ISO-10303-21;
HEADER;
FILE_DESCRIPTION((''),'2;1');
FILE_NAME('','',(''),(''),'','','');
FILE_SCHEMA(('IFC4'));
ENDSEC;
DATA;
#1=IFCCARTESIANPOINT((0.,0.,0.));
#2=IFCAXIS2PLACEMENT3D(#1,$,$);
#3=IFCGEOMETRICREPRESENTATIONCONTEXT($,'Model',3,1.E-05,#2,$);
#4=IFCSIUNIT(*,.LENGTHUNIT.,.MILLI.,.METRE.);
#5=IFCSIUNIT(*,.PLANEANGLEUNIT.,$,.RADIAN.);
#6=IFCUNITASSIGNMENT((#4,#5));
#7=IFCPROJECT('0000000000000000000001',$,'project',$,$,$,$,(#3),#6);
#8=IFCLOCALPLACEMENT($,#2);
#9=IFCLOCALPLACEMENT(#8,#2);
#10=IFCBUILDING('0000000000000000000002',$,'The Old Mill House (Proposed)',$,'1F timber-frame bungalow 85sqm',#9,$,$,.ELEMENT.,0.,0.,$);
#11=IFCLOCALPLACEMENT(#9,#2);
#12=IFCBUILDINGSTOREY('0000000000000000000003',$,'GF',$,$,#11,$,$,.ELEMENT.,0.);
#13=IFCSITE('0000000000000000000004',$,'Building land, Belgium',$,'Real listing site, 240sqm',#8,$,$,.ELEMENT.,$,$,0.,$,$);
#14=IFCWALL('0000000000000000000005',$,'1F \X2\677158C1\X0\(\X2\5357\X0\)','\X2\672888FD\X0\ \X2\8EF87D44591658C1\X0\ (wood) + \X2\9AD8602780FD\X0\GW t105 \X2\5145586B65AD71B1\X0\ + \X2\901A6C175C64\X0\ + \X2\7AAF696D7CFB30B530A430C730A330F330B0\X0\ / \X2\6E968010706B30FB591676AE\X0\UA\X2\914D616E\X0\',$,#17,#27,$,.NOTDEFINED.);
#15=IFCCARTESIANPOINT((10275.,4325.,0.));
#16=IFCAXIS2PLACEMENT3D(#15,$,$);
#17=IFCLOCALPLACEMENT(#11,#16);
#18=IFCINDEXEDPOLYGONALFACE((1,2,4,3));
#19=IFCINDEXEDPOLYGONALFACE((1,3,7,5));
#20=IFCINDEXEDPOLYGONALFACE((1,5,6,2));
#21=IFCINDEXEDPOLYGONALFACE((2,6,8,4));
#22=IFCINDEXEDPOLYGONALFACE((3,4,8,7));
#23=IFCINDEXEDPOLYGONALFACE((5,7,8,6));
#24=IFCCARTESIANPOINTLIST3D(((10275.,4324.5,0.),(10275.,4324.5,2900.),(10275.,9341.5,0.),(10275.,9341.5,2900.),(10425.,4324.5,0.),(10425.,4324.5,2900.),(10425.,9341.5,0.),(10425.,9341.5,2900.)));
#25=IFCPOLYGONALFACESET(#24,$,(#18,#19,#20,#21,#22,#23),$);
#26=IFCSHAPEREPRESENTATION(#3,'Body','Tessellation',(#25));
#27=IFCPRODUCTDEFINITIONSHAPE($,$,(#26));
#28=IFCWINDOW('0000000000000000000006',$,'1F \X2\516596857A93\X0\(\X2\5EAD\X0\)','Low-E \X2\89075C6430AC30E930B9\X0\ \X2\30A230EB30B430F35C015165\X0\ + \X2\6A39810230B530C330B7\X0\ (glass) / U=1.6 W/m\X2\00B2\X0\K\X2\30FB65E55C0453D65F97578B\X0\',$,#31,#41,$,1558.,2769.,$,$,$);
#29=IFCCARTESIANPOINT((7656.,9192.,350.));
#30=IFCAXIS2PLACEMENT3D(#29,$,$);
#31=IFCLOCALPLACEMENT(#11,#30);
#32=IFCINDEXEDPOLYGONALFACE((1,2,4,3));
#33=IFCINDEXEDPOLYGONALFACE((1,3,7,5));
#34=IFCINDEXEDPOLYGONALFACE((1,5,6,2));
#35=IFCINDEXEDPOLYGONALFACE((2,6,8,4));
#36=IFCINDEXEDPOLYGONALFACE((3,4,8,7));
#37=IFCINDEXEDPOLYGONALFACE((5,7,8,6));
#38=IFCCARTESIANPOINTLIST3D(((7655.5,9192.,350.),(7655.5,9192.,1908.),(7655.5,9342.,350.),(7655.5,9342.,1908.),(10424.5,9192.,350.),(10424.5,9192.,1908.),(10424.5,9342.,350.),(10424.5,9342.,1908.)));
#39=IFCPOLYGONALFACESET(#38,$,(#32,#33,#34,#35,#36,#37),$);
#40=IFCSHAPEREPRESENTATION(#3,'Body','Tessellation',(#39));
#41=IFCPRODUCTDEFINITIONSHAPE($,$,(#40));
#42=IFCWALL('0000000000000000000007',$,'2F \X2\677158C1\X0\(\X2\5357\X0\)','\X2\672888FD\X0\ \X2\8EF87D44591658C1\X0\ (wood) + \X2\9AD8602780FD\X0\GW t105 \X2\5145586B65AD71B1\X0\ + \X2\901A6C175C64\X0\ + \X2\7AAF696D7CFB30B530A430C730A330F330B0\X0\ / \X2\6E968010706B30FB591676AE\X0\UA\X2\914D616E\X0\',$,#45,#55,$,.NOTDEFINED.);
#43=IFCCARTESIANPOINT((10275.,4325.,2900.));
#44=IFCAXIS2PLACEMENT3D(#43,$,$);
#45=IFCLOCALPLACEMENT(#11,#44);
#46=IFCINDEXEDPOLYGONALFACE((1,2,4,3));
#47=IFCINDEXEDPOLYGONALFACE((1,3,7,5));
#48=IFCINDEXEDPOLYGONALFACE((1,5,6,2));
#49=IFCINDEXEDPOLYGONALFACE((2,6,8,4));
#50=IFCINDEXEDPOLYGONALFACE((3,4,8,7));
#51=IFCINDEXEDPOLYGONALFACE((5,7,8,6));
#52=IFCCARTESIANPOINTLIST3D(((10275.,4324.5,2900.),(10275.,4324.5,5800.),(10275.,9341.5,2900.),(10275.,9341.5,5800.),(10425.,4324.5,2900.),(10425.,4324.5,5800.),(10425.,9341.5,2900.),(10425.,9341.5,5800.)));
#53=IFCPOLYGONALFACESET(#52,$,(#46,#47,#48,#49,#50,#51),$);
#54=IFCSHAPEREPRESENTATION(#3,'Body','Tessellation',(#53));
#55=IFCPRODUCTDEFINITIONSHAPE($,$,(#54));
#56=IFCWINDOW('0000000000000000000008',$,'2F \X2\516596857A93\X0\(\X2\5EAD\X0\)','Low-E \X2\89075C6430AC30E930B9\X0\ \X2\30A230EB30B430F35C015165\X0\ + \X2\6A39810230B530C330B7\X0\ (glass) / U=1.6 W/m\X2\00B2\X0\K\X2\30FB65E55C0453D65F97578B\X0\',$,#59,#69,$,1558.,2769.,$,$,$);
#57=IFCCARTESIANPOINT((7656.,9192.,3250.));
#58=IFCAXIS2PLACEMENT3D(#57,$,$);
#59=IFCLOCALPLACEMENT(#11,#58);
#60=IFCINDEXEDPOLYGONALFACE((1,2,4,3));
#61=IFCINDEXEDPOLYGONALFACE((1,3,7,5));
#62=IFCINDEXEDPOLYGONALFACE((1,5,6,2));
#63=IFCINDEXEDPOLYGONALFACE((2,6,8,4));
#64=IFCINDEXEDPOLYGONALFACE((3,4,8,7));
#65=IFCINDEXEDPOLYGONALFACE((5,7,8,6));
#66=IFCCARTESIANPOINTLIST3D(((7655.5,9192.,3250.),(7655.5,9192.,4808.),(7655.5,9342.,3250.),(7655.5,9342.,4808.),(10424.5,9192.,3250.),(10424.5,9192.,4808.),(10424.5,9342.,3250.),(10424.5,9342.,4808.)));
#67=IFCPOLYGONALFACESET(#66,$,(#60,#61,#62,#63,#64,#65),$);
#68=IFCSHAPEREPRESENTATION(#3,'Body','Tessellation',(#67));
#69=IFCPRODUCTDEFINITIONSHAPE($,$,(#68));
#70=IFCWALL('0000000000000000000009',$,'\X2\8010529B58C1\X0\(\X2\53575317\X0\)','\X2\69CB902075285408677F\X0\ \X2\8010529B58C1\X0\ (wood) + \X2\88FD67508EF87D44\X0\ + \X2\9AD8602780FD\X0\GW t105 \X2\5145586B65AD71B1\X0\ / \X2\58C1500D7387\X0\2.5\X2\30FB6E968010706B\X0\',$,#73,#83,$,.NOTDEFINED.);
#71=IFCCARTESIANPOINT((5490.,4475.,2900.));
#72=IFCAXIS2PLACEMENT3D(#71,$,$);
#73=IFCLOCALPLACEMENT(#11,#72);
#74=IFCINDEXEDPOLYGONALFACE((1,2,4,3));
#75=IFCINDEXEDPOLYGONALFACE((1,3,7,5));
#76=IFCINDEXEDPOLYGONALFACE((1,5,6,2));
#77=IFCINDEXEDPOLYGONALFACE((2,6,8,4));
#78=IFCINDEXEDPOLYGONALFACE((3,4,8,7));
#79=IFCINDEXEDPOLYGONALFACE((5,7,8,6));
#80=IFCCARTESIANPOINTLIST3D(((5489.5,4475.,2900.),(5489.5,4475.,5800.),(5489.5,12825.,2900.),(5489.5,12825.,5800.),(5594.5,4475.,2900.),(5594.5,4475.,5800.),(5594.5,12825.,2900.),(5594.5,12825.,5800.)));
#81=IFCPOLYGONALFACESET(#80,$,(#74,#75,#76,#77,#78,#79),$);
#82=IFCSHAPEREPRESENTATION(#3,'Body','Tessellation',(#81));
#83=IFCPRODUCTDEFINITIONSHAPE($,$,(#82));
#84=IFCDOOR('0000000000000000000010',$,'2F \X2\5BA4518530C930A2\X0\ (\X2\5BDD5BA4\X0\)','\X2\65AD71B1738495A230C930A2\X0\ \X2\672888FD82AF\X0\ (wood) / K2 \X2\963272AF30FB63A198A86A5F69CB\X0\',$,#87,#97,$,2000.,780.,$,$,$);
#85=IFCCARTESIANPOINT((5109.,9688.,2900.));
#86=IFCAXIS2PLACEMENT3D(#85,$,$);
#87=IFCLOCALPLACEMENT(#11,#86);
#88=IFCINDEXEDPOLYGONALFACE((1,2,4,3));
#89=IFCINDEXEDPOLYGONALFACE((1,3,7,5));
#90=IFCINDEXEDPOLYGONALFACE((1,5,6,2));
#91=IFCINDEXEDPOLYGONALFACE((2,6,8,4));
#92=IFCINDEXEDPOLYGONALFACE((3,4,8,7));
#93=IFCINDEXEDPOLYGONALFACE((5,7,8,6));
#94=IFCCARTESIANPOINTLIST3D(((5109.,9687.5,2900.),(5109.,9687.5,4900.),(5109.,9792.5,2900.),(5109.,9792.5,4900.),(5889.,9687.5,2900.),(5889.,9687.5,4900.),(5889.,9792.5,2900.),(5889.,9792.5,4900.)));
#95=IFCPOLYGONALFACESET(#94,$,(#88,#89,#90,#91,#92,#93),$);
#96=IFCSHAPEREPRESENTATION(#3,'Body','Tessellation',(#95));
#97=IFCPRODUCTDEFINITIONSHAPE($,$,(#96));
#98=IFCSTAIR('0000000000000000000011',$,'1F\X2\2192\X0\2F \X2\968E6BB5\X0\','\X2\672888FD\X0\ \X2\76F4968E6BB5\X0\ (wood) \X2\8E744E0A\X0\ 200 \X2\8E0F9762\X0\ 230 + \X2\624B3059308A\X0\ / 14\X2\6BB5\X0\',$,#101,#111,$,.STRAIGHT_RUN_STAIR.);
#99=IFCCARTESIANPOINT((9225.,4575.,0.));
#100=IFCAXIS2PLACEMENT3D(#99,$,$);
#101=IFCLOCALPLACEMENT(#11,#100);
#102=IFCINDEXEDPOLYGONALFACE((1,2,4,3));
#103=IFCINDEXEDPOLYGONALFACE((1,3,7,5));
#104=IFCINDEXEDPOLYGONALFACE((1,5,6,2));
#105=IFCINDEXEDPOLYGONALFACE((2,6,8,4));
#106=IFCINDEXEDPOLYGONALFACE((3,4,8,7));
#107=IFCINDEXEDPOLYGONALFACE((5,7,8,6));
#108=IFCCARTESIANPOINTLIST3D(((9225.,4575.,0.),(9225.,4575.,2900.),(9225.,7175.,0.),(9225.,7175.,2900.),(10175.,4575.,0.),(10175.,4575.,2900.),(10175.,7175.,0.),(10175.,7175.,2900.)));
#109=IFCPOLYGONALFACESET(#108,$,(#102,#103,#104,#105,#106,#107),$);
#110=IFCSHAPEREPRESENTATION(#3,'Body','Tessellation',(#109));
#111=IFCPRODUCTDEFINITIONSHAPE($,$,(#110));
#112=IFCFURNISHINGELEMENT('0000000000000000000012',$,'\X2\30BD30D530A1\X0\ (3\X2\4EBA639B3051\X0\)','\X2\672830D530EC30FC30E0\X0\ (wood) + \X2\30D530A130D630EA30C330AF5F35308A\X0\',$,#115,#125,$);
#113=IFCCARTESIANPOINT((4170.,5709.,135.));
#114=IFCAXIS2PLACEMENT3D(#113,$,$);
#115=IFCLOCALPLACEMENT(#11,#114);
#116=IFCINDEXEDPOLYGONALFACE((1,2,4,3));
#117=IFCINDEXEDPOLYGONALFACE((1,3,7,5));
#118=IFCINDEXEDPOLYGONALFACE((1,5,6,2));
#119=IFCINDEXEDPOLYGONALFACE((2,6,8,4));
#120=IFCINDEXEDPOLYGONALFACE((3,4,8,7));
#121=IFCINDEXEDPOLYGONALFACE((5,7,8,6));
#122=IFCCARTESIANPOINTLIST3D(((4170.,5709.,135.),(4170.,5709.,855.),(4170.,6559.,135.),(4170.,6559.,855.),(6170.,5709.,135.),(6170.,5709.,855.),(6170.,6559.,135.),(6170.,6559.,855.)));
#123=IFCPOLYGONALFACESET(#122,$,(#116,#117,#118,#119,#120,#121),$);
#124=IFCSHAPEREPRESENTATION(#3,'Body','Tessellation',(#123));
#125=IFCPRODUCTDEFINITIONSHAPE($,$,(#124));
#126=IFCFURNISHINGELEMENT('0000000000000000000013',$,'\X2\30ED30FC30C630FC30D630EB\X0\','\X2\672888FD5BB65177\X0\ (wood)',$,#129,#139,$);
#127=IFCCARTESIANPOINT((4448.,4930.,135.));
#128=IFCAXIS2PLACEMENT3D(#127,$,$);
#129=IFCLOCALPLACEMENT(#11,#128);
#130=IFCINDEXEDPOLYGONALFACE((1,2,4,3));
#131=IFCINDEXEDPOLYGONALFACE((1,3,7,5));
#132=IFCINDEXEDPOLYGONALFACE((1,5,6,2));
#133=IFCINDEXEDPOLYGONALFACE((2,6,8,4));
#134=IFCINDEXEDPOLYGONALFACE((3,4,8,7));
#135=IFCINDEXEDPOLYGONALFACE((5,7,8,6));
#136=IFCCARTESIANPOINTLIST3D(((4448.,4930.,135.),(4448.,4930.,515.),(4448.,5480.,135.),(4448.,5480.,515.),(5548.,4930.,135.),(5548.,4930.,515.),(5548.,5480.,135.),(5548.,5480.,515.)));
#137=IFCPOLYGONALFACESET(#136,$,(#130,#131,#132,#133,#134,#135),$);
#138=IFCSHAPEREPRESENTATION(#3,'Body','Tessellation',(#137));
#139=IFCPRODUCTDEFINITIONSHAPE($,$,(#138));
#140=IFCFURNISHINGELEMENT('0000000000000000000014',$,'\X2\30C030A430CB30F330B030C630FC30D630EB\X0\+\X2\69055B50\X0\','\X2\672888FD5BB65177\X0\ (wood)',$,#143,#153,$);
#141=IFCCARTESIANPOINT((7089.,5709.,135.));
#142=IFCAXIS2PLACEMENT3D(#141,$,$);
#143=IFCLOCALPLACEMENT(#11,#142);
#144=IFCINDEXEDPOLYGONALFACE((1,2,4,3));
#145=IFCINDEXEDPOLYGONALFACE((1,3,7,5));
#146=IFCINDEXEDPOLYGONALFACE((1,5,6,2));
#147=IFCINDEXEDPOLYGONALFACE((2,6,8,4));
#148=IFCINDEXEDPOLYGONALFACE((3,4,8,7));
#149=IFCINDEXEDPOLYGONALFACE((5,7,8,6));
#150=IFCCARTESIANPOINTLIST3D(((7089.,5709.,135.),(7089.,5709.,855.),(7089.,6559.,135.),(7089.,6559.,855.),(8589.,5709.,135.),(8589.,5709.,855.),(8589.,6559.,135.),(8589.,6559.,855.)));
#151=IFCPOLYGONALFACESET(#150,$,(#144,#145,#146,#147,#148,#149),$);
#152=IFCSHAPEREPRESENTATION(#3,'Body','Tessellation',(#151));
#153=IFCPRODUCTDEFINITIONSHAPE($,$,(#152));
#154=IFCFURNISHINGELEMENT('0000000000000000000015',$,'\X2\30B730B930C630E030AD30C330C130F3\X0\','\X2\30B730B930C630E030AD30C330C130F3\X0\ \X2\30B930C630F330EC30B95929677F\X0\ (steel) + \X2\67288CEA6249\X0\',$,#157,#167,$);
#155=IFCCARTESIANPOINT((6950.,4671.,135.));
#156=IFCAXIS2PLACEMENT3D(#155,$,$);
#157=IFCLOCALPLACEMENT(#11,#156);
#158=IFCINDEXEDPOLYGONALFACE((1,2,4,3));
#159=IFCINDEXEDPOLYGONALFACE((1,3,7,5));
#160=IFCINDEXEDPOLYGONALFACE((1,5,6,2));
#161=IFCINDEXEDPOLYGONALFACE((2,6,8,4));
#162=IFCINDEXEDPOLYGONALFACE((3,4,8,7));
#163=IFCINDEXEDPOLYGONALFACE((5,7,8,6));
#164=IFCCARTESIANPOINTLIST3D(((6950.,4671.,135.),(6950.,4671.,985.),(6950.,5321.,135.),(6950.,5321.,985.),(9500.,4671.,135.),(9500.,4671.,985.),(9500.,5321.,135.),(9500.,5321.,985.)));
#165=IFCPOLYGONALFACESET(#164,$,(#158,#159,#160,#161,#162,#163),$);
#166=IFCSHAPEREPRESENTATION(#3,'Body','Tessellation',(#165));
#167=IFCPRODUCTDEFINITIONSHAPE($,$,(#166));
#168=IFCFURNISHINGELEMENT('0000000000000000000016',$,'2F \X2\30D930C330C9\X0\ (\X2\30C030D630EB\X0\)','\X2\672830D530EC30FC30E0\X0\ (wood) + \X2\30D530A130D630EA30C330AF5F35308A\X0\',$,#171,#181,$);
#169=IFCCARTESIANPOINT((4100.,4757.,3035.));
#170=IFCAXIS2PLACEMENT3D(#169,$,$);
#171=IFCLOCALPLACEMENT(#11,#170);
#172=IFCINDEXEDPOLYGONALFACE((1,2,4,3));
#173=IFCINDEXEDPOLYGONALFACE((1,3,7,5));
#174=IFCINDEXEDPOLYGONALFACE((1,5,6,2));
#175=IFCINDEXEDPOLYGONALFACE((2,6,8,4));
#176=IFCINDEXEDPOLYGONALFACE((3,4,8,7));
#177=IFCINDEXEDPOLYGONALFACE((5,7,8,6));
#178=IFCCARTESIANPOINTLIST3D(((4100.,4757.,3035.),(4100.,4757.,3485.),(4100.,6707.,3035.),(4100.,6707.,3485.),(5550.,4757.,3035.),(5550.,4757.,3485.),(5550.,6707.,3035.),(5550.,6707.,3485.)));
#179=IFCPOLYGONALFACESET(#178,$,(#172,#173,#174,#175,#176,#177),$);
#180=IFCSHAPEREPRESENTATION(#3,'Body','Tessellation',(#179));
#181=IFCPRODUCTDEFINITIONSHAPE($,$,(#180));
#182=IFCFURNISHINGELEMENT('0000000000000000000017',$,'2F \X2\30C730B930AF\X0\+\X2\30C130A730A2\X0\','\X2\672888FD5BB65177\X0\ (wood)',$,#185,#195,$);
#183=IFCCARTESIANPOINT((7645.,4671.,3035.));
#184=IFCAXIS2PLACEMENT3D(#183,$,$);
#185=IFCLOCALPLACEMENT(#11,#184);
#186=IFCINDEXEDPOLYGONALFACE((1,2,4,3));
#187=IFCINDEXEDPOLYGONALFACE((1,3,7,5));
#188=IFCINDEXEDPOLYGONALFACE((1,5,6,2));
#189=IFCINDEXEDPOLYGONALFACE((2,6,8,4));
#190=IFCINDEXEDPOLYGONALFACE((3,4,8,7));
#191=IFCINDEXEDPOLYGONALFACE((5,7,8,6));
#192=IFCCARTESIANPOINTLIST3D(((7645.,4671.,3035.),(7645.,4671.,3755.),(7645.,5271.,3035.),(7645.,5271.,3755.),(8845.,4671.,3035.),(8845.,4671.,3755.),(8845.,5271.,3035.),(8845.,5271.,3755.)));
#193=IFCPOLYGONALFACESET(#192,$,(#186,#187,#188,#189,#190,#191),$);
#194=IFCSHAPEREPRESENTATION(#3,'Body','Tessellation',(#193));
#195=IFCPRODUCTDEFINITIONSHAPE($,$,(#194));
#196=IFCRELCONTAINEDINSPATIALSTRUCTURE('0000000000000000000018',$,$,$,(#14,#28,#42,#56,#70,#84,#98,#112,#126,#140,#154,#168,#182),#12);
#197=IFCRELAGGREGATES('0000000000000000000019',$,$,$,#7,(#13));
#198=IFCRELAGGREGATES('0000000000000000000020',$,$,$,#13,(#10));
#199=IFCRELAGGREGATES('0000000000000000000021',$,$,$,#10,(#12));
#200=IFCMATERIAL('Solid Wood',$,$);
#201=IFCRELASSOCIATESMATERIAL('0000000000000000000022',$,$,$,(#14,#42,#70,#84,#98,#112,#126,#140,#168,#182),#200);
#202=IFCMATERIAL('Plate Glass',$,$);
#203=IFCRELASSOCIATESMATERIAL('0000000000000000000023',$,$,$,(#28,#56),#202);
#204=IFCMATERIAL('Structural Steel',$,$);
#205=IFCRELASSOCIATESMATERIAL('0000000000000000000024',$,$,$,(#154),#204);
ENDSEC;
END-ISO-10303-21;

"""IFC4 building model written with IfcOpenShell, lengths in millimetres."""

from ifc_helpers import new_model, si_unit, frame, frame_2d, origin, place, context, project, spatial, rectangle, extrude, material, element, fill, save


model = new_model("IFC4")

# Units and contexts
model_context = context("Model", 3, precision=1e-05, world=origin())
ifc_project = project(units=[si_unit("LENGTHUNIT", "METRE", prefix="MILLI"), si_unit("PLANEANGLEUNIT", "RADIAN")], contexts=[model_context])

# Site, building, storey
site_placement = place(None, origin())
site = spatial("IfcSite", under=ifc_project, at=site_placement, Name="Building land, Belgium", ObjectType="Real listing site, 240sqm", CompositionType="ELEMENT", RefElevation=0.0)
building_placement = place(site_placement, origin())
building = spatial("IfcBuilding", under=site, at=building_placement, Name="The Old Mill House (Proposed)", ObjectType="1F timber-frame bungalow 85sqm", CompositionType="ELEMENT", ElevationOfRefHeight=0.0, ElevationOfTerrain=0.0)
storey_placement = place(building_placement, origin())
storey = spatial("IfcBuildingStorey", under=building, at=storey_placement, Name="GF", CompositionType="ELEMENT", Elevation=0.0)

# Wall, opening, window
ifc_material_1 = material(Name="Solid Wood")
wall_1_placement = place(storey_placement, frame((10275.0, 4325.0, 0.0)))
wall_1 = element("IfcWall", 1, at=wall_1_placement, inside=storey, material=ifc_material_1, Name="1F 東壁(南)", Description="木製 軸組外壁 (wood) + 高性能GW t105 充填断熱 + 通気層 + 窯業系サイディング / 準耐火・外皮UA配慮", PredefinedType="NOTDEFINED", context=model_context, shape_type="SweptSolid", body=[
    extrude(rectangle(XDim=150.0, YDim=5017.0, at=frame_2d((75.0, 2508.0))), frame((10275.0, 4325.0, 0.0)), (0.0, 0.0, 1.0), 2900.0),
])
opening_1_placement = place(storey_placement, frame((7656.0, 9192.0, 350.0)))
opening_1 = element("IfcOpeningElement", 2, at=opening_1_placement, cuts=wall_1, PredefinedType="NOTDEFINED", context=model_context, shape_type="SweptSolid", body=[
    extrude(rectangle(XDim=2769.0, YDim=150.0, at=frame_2d((1384.0, 75.0))), frame((7656.0, 9192.0, 350.0)), (0.0, 0.0, 1.0), 1558.0),
])
ifc_material_2 = material(Name="Plate Glass")
window_1_placement = place(storey_placement, frame((7656.0, 9192.0, 350.0)))
window_1 = element("IfcWindow", 3, at=window_1_placement, inside=storey, material=ifc_material_2, Name="1F 入隅窓(庭)", Description="Low-E 複層ガラス アルゴン封入 + 樹脂サッシ (glass) / U=1.6 W/m²K・日射取得型", OverallHeight=1558.0, OverallWidth=2769.0, context=model_context, shape_type="SweptSolid", body=[
    extrude(rectangle(XDim=2769.0, YDim=150.0, at=frame_2d((1384.0, 75.0))), frame((7656.0, 9192.0, 350.0)), (0.0, 0.0, 1.0), 1558.0),
])
fill(opening_1, window_1)

# Wall, opening, window
wall_2_placement = place(storey_placement, frame((10275.0, 4325.0, 2900.0)))
wall_2 = element("IfcWall", 4, at=wall_2_placement, inside=storey, material=ifc_material_1, Name="2F 東壁(南)", Description="木製 軸組外壁 (wood) + 高性能GW t105 充填断熱 + 通気層 + 窯業系サイディング / 準耐火・外皮UA配慮", PredefinedType="NOTDEFINED", context=model_context, shape_type="SweptSolid", body=[
    extrude(rectangle(XDim=150.0, YDim=5017.0, at=frame_2d((75.0, 2508.0))), frame((10275.0, 4325.0, 2900.0)), (0.0, 0.0, 1.0), 2900.0),
])
opening_2_placement = place(storey_placement, frame((7656.0, 9192.0, 3250.0)))
opening_2 = element("IfcOpeningElement", 5, at=opening_2_placement, cuts=wall_2, PredefinedType="NOTDEFINED", context=model_context, shape_type="SweptSolid", body=[
    extrude(rectangle(XDim=2769.0, YDim=150.0, at=frame_2d((1384.0, 75.0))), frame((7656.0, 9192.0, 3250.0)), (0.0, 0.0, 1.0), 1558.0),
])
window_2_placement = place(storey_placement, frame((7656.0, 9192.0, 3250.0)))
window_2 = element("IfcWindow", 6, at=window_2_placement, inside=storey, material=ifc_material_2, Name="2F 入隅窓(庭)", Description="Low-E 複層ガラス アルゴン封入 + 樹脂サッシ (glass) / U=1.6 W/m²K・日射取得型", OverallHeight=1558.0, OverallWidth=2769.0, context=model_context, shape_type="SweptSolid", body=[
    extrude(rectangle(XDim=2769.0, YDim=150.0, at=frame_2d((1384.0, 75.0))), frame((7656.0, 9192.0, 3250.0)), (0.0, 0.0, 1.0), 1558.0),
])
fill(opening_2, window_2)

# Wall, opening, door
wall_3_placement = place(storey_placement, frame((5490.0, 4475.0, 2900.0)))
wall_3 = element("IfcWall", 7, at=wall_3_placement, inside=storey, material=ifc_material_1, Name="耐力壁(南北)", Description="構造用合板 耐力壁 (wood) + 製材軸組 + 高性能GW t105 充填断熱 / 壁倍率2.5・準耐火", PredefinedType="NOTDEFINED", context=model_context, shape_type="SweptSolid", body=[
    extrude(rectangle(XDim=105.0, YDim=8350.0, at=frame_2d((52.0, 4175.0))), frame((5490.0, 4475.0, 2900.0)), (0.0, 0.0, 1.0), 2900.0),
])
opening_3_placement = place(storey_placement, frame((5109.0, 9688.0, 2900.0)))
opening_3 = element("IfcOpeningElement", 8, at=opening_3_placement, cuts=wall_3, PredefinedType="NOTDEFINED", context=model_context, shape_type="SweptSolid", body=[
    extrude(rectangle(XDim=780.0, YDim=105.0, at=frame_2d((390.0, 52.0))), frame((5109.0, 9688.0, 2900.0)), (0.0, 0.0, 1.0), 2000.0),
])
door_1_placement = place(storey_placement, frame((5109.0, 9688.0, 2900.0)))
door_1 = element("IfcDoor", 9, at=door_1_placement, inside=storey, material=ifc_material_1, Name="2F 室内ドア (寝室)", Description="断熱玄関ドア 木製芯 (wood) / K2 防犯・採風機構", OverallHeight=2000.0, OverallWidth=780.0, context=model_context, shape_type="SweptSolid", body=[
    extrude(rectangle(XDim=780.0, YDim=105.0, at=frame_2d((390.0, 52.0))), frame((5109.0, 9688.0, 2900.0)), (0.0, 0.0, 1.0), 2000.0),
])
fill(opening_3, door_1)

# Stair
stair_placement = place(storey_placement, frame((9225.0, 4575.0, 0.0)))
element("IfcStair", 10, at=stair_placement, inside=storey, material=ifc_material_1, Name="1F→2F 階段", Description="木製 直階段 (wood) 蹴上 200 踏面 230 + 手すり / 14段", PredefinedType="STRAIGHT_RUN_STAIR", context=model_context, shape_type="SweptSolid", body=[
    extrude(rectangle(XDim=950.0, YDim=2600.0, at=frame_2d((475.0, 1300.0))), frame((9225.0, 4575.0, 0.0)), (0.0, 0.0, 1.0), 2900.0),
])

# Furnishing elements
furnishing_1_placement = place(storey_placement, frame((4170.0, 5709.0, 135.0)))
element("IfcFurnishingElement", 11, at=furnishing_1_placement, inside=storey, material=ifc_material_1, Name="ソファ (3人掛け)", Description="木フレーム (wood) + ファブリック張り", context=model_context, shape_type="SweptSolid", body=[
    extrude(rectangle(XDim=2000.0, YDim=850.0, at=frame_2d((1000.0, 425.0))), frame((4170.0, 5709.0, 135.0)), (0.0, 0.0, 1.0), 720.0),
])
furnishing_2_placement = place(storey_placement, frame((4448.0, 4930.0, 135.0)))
element("IfcFurnishingElement", 12, at=furnishing_2_placement, inside=storey, material=ifc_material_1, Name="ローテーブル", Description="木製家具 (wood)", context=model_context, shape_type="SweptSolid", body=[
    extrude(rectangle(XDim=1100.0, YDim=550.0, at=frame_2d((550.0, 275.0))), frame((4448.0, 4930.0, 135.0)), (0.0, 0.0, 1.0), 380.0),
])
furnishing_3_placement = place(storey_placement, frame((7089.0, 5709.0, 135.0)))
element("IfcFurnishingElement", 13, at=furnishing_3_placement, inside=storey, material=ifc_material_1, Name="ダイニングテーブル+椅子", Description="木製家具 (wood)", context=model_context, shape_type="SweptSolid", body=[
    extrude(rectangle(XDim=1500.0, YDim=850.0, at=frame_2d((750.0, 425.0))), frame((7089.0, 5709.0, 135.0)), (0.0, 0.0, 1.0), 720.0),
])
ifc_material_3 = material(Name="Structural Steel")
furnishing_4_placement = place(storey_placement, frame((6950.0, 4671.0, 135.0)))
element("IfcFurnishingElement", 14, at=furnishing_4_placement, inside=storey, material=ifc_material_3, Name="システムキッチン", Description="システムキッチン ステンレス天板 (steel) + 木質扉", context=model_context, shape_type="SweptSolid", body=[
    extrude(rectangle(XDim=2550.0, YDim=650.0, at=frame_2d((1275.0, 325.0))), frame((6950.0, 4671.0, 135.0)), (0.0, 0.0, 1.0), 850.0),
])
furnishing_5_placement = place(storey_placement, frame((4100.0, 4757.0, 3035.0)))
element("IfcFurnishingElement", 15, at=furnishing_5_placement, inside=storey, material=ifc_material_1, Name="2F ベッド (ダブル)", Description="木フレーム (wood) + ファブリック張り", context=model_context, shape_type="SweptSolid", body=[
    extrude(rectangle(XDim=1450.0, YDim=1950.0, at=frame_2d((725.0, 975.0))), frame((4100.0, 4757.0, 3035.0)), (0.0, 0.0, 1.0), 450.0),
])
furnishing_6_placement = place(storey_placement, frame((7645.0, 4671.0, 3035.0)))
element("IfcFurnishingElement", 16, at=furnishing_6_placement, inside=storey, material=ifc_material_1, Name="2F デスク+チェア", Description="木製家具 (wood)", context=model_context, shape_type="SweptSolid", body=[
    extrude(rectangle(XDim=1200.0, YDim=600.0, at=frame_2d((600.0, 300.0))), frame((7645.0, 4671.0, 3035.0)), (0.0, 0.0, 1.0), 720.0),
])

save(model, "model.ifc")
